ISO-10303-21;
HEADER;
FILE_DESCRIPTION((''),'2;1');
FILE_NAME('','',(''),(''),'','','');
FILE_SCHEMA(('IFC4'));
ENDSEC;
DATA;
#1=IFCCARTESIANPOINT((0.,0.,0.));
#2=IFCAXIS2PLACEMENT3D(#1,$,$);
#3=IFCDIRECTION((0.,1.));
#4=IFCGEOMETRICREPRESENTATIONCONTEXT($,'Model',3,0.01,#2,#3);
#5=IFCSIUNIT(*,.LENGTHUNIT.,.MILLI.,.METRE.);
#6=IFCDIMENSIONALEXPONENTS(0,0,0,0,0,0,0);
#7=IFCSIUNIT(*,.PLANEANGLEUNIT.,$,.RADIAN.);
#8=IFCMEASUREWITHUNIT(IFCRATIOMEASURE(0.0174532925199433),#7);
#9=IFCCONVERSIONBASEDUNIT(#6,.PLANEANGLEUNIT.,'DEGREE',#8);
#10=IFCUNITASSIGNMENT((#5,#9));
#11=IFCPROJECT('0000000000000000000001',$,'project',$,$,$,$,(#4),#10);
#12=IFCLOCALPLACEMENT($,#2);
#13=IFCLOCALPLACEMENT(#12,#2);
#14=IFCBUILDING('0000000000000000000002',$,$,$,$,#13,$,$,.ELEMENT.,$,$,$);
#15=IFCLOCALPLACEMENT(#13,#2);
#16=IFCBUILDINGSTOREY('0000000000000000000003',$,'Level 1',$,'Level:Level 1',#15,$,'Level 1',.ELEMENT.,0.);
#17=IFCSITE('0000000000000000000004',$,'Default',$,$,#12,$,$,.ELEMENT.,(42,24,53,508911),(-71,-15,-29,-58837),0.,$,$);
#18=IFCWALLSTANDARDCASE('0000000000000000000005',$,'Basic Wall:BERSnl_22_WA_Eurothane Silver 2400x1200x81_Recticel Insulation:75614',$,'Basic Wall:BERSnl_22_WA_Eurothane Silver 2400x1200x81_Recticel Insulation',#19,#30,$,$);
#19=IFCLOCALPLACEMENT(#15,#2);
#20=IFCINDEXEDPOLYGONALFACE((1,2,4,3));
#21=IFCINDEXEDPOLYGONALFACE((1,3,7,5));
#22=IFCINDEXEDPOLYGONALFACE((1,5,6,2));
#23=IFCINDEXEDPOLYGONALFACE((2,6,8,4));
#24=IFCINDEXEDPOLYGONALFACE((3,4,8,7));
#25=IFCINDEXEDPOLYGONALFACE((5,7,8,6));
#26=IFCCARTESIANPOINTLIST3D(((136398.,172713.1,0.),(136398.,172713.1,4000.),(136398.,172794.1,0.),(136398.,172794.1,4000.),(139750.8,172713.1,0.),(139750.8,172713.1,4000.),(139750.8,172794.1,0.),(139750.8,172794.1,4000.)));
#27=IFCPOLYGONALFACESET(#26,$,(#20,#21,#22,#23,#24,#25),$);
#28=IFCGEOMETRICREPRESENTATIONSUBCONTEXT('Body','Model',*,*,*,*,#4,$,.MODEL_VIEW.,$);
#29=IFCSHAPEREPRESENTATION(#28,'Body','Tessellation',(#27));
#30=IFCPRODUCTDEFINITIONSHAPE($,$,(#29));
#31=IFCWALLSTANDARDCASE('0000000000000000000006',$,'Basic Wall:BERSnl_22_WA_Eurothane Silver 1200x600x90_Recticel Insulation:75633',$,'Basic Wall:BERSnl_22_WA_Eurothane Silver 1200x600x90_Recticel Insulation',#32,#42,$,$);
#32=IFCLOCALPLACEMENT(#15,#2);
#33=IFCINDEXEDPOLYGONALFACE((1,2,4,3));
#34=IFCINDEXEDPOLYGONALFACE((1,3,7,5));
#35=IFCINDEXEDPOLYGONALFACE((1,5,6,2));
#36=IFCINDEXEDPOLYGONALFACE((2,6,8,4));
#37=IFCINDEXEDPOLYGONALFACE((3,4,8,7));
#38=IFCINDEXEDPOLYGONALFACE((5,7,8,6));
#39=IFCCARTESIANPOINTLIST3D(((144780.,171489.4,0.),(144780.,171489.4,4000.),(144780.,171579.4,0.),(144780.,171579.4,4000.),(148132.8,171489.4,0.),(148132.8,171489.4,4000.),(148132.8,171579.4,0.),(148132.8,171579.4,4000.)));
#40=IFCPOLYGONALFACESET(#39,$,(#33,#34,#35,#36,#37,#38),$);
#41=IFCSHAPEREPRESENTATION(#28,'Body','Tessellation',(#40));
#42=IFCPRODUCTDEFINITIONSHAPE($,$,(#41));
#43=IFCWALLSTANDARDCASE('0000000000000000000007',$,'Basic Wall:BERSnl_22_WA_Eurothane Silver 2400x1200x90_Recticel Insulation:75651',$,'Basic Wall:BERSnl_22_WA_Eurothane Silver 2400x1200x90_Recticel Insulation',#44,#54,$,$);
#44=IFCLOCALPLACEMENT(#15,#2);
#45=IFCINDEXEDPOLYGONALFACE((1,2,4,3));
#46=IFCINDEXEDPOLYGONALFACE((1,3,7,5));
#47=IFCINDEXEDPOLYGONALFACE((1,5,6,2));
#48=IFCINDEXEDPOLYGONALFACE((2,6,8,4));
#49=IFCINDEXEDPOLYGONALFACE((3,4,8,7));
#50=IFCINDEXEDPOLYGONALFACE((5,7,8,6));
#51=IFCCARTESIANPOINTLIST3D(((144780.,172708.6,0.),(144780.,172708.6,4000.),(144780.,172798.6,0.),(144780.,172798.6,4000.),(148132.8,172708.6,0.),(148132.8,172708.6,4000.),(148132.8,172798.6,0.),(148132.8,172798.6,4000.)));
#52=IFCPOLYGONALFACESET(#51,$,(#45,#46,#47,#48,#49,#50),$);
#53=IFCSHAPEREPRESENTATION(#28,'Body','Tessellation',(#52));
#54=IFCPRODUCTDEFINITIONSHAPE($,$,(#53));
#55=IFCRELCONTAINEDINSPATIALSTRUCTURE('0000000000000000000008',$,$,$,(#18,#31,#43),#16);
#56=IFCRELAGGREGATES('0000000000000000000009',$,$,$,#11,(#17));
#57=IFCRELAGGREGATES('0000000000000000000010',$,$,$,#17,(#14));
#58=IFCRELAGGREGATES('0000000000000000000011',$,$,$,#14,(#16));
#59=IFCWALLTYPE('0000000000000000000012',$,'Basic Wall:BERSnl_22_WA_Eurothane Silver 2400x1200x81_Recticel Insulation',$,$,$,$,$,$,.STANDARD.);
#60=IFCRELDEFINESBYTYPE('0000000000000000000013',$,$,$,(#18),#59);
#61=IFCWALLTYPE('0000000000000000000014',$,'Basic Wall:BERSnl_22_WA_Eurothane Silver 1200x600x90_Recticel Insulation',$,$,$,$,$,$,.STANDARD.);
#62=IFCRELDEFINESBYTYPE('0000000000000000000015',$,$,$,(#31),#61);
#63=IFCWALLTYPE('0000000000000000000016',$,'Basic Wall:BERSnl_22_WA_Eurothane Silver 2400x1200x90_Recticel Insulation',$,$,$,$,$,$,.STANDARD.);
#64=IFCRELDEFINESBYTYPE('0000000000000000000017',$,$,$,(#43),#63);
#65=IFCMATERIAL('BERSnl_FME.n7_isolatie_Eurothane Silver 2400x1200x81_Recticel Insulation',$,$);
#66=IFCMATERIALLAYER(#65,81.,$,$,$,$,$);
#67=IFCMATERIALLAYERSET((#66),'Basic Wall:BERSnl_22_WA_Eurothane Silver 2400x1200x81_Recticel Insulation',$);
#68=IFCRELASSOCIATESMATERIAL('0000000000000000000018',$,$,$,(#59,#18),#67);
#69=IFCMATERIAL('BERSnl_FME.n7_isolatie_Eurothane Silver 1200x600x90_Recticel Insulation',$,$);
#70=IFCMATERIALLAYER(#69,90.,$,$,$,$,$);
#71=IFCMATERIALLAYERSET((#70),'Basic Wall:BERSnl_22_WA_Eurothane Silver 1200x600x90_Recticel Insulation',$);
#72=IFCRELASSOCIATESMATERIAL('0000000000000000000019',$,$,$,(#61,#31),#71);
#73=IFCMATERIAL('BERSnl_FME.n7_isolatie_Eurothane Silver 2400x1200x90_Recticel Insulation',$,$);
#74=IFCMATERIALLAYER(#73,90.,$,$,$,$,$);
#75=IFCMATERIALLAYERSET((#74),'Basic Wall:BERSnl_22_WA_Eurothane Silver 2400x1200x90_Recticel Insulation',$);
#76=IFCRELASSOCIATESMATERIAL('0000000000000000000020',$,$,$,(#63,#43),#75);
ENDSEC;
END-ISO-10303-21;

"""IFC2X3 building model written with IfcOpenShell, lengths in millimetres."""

from ifc_helpers import new_model, entity, si_unit, converted_unit, direction, frame, frame_2d, origin, place, context, subcontext, project, spatial, rectangle, extrude, material, layer, layer_set, layer_usage, type_object, element, save


model = new_model("IFC2X3")

# Units and contexts
model_context = context("Model", 3, precision=0.01, world=origin(), true_north=direction((0.0, 1.0)))
body_context = subcontext(model_context, "Body", "Model", "MODEL_VIEW")
ifc_project = project(units=[si_unit("LENGTHUNIT", "METRE", prefix="MILLI"), converted_unit("PLANEANGLEUNIT", "DEGREE", entity("IfcRatioMeasure", 0.0174532925199433), si_unit("PLANEANGLEUNIT", "RADIAN"), dimensions=[0, 0, 0, 0, 0, 0, 0])], contexts=[model_context])

# Site, building, storey
site_placement = place(None, origin())
site = spatial("IfcSite", under=ifc_project, at=site_placement, Name="Default", CompositionType="ELEMENT", RefLatitude=(42, 24, 53, 508911), RefLongitude=(-71, -15, -29, -58837), RefElevation=0.0)
building_placement = place(site_placement, origin())
building = spatial("IfcBuilding", under=site, at=building_placement, CompositionType="ELEMENT")
storey_placement = place(building_placement, origin())
storey = spatial("IfcBuildingStorey", under=building, at=storey_placement, Name="Level 1", ObjectType="Level:Level 1", LongName="Level 1", CompositionType="ELEMENT", Elevation=0.0)

# Shared definitions
ifc_material_1 = material(Name="BERSnl_FME.n7_isolatie_Eurothane Silver 2400x1200x81_Recticel Insulation")
ifc_material_2 = material(Name="BERSnl_FME.n7_isolatie_Eurothane Silver 1200x600x90_Recticel Insulation")
ifc_material_3 = material(Name="BERSnl_FME.n7_isolatie_Eurothane Silver 2400x1200x90_Recticel Insulation")

# Walls
ifc_layer_1 = layer(ifc_material_1, 81.0)
ifc_layer_set_1 = layer_set([ifc_layer_1], Name="Basic Wall:BERSnl_22_WA_Eurothane Silver 2400x1200x81_Recticel Insulation")
ifc_layer_usage_1 = layer_usage(ifc_layer_set_1, "AXIS2", "NEGATIVE", 40.5)
wall_type_1 = type_object("IfcWallType", Name="Basic Wall:BERSnl_22_WA_Eurothane Silver 2400x1200x81_Recticel Insulation", PredefinedType="STANDARD", material=ifc_layer_set_1)
wall_1_placement = place(storey_placement, frame((136398.0, 172753.6, 0.0)))
element("IfcWallStandardCase", 1, at=wall_1_placement, inside=storey, type_object=wall_type_1, material=ifc_layer_usage_1, Name="Basic Wall:BERSnl_22_WA_Eurothane Silver 2400x1200x81_Recticel Insulation:75614", ObjectType="Basic Wall:BERSnl_22_WA_Eurothane Silver 2400x1200x81_Recticel Insulation", context=body_context, shape_type="SweptSolid", body=[
    extrude(rectangle(XDim=3352.8, YDim=81.0, at=frame_2d((1676.4, 0.0), x_axis=(-1.0, 0.0))), origin(), (0.0, 0.0, 1.0), 4000.0),
])
ifc_layer_2 = layer(ifc_material_2, 90.0)
ifc_layer_set_2 = layer_set([ifc_layer_2], Name="Basic Wall:BERSnl_22_WA_Eurothane Silver 1200x600x90_Recticel Insulation")
ifc_layer_usage_2 = layer_usage(ifc_layer_set_2, "AXIS2", "NEGATIVE", 45.0)
wall_type_2 = type_object("IfcWallType", Name="Basic Wall:BERSnl_22_WA_Eurothane Silver 1200x600x90_Recticel Insulation", PredefinedType="STANDARD", material=ifc_layer_set_2)
wall_2_placement = place(storey_placement, frame((144780.0, 171534.4, 0.0)))
element("IfcWallStandardCase", 2, at=wall_2_placement, inside=storey, type_object=wall_type_2, material=ifc_layer_usage_2, Name="Basic Wall:BERSnl_22_WA_Eurothane Silver 1200x600x90_Recticel Insulation:75633", ObjectType="Basic Wall:BERSnl_22_WA_Eurothane Silver 1200x600x90_Recticel Insulation", context=body_context, shape_type="SweptSolid", body=[
    extrude(rectangle(XDim=3352.8, YDim=90.0, at=frame_2d((1676.4, 0.0), x_axis=(-1.0, 0.0))), origin(), (0.0, 0.0, 1.0), 4000.0),
])
ifc_layer_3 = layer(ifc_material_3, 90.0)
ifc_layer_set_3 = layer_set([ifc_layer_3], Name="Basic Wall:BERSnl_22_WA_Eurothane Silver 2400x1200x90_Recticel Insulation")
ifc_layer_usage_3 = layer_usage(ifc_layer_set_3, "AXIS2", "NEGATIVE", 45.0)
wall_type_3 = type_object("IfcWallType", Name="Basic Wall:BERSnl_22_WA_Eurothane Silver 2400x1200x90_Recticel Insulation", PredefinedType="STANDARD", material=ifc_layer_set_3)
wall_3_placement = place(storey_placement, frame((144780.0, 172753.6, 0.0)))
element("IfcWallStandardCase", 3, at=wall_3_placement, inside=storey, type_object=wall_type_3, material=ifc_layer_usage_3, Name="Basic Wall:BERSnl_22_WA_Eurothane Silver 2400x1200x90_Recticel Insulation:75651", ObjectType="Basic Wall:BERSnl_22_WA_Eurothane Silver 2400x1200x90_Recticel Insulation", context=body_context, shape_type="SweptSolid", body=[
    extrude(rectangle(XDim=3352.8, YDim=90.0, at=frame_2d((1676.4, 0.0), x_axis=(-1.0, 0.0))), origin(), (0.0, 0.0, 1.0), 4000.0),
])

save(model, "model.ifc")
